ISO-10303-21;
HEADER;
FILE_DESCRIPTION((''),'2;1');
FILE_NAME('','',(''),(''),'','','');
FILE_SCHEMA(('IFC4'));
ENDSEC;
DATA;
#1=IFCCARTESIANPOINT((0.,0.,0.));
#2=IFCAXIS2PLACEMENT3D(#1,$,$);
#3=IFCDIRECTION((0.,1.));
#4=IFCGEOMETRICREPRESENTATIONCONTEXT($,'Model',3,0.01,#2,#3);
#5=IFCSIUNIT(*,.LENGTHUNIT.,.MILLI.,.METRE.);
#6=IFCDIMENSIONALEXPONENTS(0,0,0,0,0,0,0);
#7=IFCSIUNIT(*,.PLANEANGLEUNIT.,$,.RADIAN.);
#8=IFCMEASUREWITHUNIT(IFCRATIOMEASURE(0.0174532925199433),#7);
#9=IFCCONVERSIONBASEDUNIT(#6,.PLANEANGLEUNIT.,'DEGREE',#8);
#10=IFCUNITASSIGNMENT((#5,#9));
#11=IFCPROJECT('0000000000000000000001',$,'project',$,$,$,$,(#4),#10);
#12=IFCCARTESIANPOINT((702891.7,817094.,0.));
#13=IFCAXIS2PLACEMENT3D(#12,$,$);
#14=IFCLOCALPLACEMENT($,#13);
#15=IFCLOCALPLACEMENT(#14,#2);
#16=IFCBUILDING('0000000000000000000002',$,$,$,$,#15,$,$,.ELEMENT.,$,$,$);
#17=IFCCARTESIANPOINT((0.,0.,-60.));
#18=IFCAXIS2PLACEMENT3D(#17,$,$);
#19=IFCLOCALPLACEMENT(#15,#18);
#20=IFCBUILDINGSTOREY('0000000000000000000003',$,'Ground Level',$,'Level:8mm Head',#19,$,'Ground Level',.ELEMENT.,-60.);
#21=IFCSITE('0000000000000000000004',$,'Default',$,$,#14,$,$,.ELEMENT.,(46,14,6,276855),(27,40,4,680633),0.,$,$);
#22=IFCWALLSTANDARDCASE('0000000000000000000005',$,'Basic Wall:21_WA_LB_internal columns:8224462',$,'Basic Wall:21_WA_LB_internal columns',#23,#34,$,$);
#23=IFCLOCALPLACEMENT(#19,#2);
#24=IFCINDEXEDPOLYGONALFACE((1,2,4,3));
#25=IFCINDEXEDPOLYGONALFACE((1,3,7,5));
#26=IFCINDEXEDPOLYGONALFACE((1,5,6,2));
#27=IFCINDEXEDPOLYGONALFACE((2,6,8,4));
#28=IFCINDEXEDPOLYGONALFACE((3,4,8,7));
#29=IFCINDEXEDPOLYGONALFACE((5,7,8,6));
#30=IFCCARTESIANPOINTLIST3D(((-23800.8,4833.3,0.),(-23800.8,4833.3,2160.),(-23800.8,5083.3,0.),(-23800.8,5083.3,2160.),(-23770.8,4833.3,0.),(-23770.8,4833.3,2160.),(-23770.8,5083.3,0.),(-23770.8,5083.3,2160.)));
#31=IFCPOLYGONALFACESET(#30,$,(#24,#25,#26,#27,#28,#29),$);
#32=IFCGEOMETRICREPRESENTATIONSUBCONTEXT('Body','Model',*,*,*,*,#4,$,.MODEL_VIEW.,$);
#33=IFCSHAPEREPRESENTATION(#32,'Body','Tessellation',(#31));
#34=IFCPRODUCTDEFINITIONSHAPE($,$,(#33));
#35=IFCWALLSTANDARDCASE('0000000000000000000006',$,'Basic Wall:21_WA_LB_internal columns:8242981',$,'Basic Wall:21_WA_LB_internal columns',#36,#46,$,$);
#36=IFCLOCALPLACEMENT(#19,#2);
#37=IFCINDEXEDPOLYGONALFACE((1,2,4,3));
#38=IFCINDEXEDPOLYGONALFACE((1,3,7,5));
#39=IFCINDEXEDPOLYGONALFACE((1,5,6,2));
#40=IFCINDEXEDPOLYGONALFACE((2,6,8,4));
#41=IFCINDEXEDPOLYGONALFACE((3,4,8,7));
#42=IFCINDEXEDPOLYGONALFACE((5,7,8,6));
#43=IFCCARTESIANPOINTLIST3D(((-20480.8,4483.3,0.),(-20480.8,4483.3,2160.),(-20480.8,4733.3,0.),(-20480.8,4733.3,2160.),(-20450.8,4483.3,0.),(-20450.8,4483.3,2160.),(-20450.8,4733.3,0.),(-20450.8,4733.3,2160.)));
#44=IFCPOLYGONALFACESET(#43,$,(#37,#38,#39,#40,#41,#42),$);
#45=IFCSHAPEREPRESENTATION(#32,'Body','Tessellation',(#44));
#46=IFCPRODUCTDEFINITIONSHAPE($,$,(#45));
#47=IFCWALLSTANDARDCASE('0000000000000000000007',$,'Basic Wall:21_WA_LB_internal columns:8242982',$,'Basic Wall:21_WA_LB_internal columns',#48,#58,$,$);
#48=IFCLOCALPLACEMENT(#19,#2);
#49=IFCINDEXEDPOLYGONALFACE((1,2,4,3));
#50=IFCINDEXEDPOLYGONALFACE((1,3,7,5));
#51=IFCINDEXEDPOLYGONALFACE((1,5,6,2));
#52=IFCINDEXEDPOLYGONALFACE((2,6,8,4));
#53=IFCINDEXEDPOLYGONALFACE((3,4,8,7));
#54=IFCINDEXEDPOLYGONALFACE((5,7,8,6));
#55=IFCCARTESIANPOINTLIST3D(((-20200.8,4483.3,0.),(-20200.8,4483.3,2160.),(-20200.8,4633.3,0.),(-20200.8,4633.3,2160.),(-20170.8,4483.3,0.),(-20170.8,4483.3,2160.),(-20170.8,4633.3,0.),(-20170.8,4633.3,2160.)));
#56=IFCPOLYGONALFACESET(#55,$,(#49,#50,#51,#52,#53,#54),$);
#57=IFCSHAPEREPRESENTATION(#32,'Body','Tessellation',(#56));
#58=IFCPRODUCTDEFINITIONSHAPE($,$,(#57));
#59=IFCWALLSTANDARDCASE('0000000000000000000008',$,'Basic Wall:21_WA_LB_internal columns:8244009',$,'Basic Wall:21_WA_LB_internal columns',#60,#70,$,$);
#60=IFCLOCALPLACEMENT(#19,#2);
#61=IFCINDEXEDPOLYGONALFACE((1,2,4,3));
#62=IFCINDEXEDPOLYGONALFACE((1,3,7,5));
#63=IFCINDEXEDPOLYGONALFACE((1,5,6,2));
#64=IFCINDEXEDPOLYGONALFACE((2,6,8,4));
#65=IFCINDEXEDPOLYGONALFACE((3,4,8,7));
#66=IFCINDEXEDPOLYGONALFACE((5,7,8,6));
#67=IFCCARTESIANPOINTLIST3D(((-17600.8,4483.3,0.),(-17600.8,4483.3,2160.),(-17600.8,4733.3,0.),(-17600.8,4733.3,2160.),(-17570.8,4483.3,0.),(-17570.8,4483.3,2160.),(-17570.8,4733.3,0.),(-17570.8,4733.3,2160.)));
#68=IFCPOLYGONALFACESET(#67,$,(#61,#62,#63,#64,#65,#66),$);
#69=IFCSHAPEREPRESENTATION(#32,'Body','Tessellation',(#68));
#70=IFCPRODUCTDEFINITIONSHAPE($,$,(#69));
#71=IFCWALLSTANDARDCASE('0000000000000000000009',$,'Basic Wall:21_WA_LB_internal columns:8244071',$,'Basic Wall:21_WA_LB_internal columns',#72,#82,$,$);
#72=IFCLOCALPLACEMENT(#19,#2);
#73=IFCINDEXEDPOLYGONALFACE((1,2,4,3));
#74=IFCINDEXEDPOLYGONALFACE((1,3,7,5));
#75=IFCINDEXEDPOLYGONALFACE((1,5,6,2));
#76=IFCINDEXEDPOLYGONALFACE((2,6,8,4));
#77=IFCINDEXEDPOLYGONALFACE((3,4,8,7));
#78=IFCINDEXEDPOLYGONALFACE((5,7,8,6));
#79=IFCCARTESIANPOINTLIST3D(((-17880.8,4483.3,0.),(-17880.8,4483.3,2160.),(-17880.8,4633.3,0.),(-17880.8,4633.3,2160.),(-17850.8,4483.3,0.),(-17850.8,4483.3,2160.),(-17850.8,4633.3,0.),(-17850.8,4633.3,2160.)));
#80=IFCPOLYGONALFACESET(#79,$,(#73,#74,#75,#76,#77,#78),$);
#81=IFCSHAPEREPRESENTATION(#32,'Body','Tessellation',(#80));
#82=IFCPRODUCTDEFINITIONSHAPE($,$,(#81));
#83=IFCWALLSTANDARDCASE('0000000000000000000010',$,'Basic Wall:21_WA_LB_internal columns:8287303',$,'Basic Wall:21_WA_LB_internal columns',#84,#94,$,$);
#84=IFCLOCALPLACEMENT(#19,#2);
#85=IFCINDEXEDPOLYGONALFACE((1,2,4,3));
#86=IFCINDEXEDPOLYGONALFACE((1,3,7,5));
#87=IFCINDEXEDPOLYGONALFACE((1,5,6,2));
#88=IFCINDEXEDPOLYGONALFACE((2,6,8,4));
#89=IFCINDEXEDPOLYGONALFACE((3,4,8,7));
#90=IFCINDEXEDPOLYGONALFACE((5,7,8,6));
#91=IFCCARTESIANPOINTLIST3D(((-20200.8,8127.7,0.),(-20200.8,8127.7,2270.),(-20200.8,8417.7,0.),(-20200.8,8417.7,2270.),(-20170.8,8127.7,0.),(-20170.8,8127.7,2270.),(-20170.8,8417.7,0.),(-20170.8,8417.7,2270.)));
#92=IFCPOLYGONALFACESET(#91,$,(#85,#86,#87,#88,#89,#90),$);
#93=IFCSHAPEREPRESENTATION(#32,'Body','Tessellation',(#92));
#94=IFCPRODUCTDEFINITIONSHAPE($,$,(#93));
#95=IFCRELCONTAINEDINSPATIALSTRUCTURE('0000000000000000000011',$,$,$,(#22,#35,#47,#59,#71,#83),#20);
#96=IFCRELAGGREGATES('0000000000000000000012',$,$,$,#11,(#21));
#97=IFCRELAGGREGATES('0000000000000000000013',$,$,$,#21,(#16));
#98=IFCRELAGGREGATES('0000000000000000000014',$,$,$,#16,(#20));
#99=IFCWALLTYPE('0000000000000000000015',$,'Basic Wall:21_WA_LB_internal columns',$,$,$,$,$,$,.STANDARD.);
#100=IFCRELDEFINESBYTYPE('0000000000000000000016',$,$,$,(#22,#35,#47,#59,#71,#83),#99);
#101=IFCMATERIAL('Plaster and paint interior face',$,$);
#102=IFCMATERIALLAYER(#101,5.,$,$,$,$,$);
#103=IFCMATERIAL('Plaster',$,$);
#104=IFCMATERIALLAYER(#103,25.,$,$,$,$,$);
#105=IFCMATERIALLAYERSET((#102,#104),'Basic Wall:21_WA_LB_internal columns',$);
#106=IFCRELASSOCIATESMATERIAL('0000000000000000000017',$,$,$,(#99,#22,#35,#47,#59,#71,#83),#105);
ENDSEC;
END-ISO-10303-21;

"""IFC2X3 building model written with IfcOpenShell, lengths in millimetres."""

from ifc_helpers import new_model, entity, si_unit, converted_unit, direction, frame, frame_2d, origin, place, context, subcontext, project, spatial, rectangle, extrude, material, layer, layer_set, layer_usage, type_object, element, save


model = new_model("IFC2X3")

# Units and contexts
model_context = context("Model", 3, precision=0.01, world=origin(), true_north=direction((0.0, 1.0)))
body_context = subcontext(model_context, "Body", "Model", "MODEL_VIEW")
ifc_project = project(units=[si_unit("LENGTHUNIT", "METRE", prefix="MILLI"), converted_unit("PLANEANGLEUNIT", "DEGREE", entity("IfcRatioMeasure", 0.0174532925199433), si_unit("PLANEANGLEUNIT", "RADIAN"), dimensions=[0, 0, 0, 0, 0, 0, 0])], contexts=[model_context])

# Site, building, storey
site_placement = place(None, frame((702891.7, 817094.0, 0.0)))
site = spatial("IfcSite", under=ifc_project, at=site_placement, Name="Default", CompositionType="ELEMENT", RefLatitude=(46, 14, 6, 276855), RefLongitude=(27, 40, 4, 680633), RefElevation=0.0)
building_placement = place(site_placement, origin())
building = spatial("IfcBuilding", under=site, at=building_placement, CompositionType="ELEMENT")
storey_placement = place(building_placement, frame((0.0, 0.0, -60.0)))
storey = spatial("IfcBuildingStorey", under=building, at=storey_placement, Name="Ground Level", ObjectType="Level:8mm Head", LongName="Ground Level", CompositionType="ELEMENT", Elevation=-60.0)

# Shared definitions
ifc_material_1 = material(Name="Plaster")
ifc_material_2 = material(Name="Plaster and paint interior face")

# Walls
ifc_layer_1 = layer(ifc_material_2, 5.0)
ifc_layer_2 = layer(ifc_material_1, 25.0)
ifc_layer_set_1 = layer_set([ifc_layer_1, ifc_layer_2], Name="Basic Wall:21_WA_LB_internal columns")
ifc_layer_usage_1 = layer_usage(ifc_layer_set_1, "AXIS2", "NEGATIVE", 15.0)
wall_type_1 = type_object("IfcWallType", Name="Basic Wall:21_WA_LB_internal columns", PredefinedType="STANDARD", material=ifc_layer_set_1)
wall_1_placement = place(storey_placement, frame((-23785.8, 5083.3, 0.0), z_axis=(0.0, 0.0, 1.0), x_axis=(0.0, -1.0, 0.0)))
element("IfcWallStandardCase", 1, at=wall_1_placement, inside=storey, type_object=wall_type_1, material=ifc_layer_usage_1, Name="Basic Wall:21_WA_LB_internal columns:8224462", ObjectType="Basic Wall:21_WA_LB_internal columns", context=body_context, shape_type="SweptSolid", body=[
    extrude(rectangle(XDim=250.0, YDim=30.0, at=frame_2d((125.0, 0.0), x_axis=(-1.0, 0.0))), origin(), (0.0, 0.0, 1.0), 2160.0),
])
ifc_layer_usage_2 = layer_usage(ifc_layer_set_1, "AXIS2", "POSITIVE", -15.0)
wall_2_placement = place(storey_placement, frame((-20465.8, 4733.3, 0.0), z_axis=(0.0, 0.0, 1.0), x_axis=(0.0, -1.0, 0.0)))
element("IfcWallStandardCase", 2, at=wall_2_placement, inside=storey, type_object=wall_type_1, material=ifc_layer_usage_2, Name="Basic Wall:21_WA_LB_internal columns:8242981", ObjectType="Basic Wall:21_WA_LB_internal columns", context=body_context, shape_type="SweptSolid", body=[
    extrude(rectangle(XDim=250.0, YDim=30.0, at=frame_2d((125.0, 0.0), x_axis=(-1.0, 0.0))), origin(), (0.0, 0.0, 1.0), 2160.0),
])
ifc_layer_usage_3 = layer_usage(ifc_layer_set_1, "AXIS2", "NEGATIVE", 15.0)
wall_3_placement = place(storey_placement, frame((-20185.8, 4633.3, 0.0), z_axis=(0.0, 0.0, 1.0), x_axis=(0.0, -1.0, 0.0)))
element("IfcWallStandardCase", 3, at=wall_3_placement, inside=storey, type_object=wall_type_1, material=ifc_layer_usage_3, Name="Basic Wall:21_WA_LB_internal columns:8242982", ObjectType="Basic Wall:21_WA_LB_internal columns", context=body_context, shape_type="SweptSolid", body=[
    extrude(rectangle(XDim=150.0, YDim=30.0, at=frame_2d((75.0, 0.0), x_axis=(-1.0, 0.0))), origin(), (0.0, 0.0, 1.0), 2160.0),
])
ifc_layer_usage_4 = layer_usage(ifc_layer_set_1, "AXIS2", "POSITIVE", -15.0)
wall_4_placement = place(storey_placement, frame((-17585.8, 4483.3, 0.0), z_axis=(0.0, 0.0, 1.0), x_axis=(0.0, 1.0, 0.0)))
element("IfcWallStandardCase", 4, at=wall_4_placement, inside=storey, type_object=wall_type_1, material=ifc_layer_usage_4, Name="Basic Wall:21_WA_LB_internal columns:8244009", ObjectType="Basic Wall:21_WA_LB_internal columns", context=body_context, shape_type="SweptSolid", body=[
    extrude(rectangle(XDim=250.0, YDim=30.0, at=frame_2d((125.0, 0.0), x_axis=(-1.0, 0.0))), origin(), (0.0, 0.0, 1.0), 2160.0),
])
ifc_layer_usage_5 = layer_usage(ifc_layer_set_1, "AXIS2", "NEGATIVE", 15.0)
wall_5_placement = place(storey_placement, frame((-17865.8, 4483.3, 0.0), z_axis=(0.0, 0.0, 1.0), x_axis=(0.0, 1.0, 0.0)))
element("IfcWallStandardCase", 5, at=wall_5_placement, inside=storey, type_object=wall_type_1, material=ifc_layer_usage_5, Name="Basic Wall:21_WA_LB_internal columns:8244071", ObjectType="Basic Wall:21_WA_LB_internal columns", context=body_context, shape_type="SweptSolid", body=[
    extrude(rectangle(XDim=150.0, YDim=30.0, at=frame_2d((75.0, 0.0), x_axis=(-1.0, 0.0))), origin(), (0.0, 0.0, 1.0), 2160.0),
])
ifc_layer_usage_6 = layer_usage(ifc_layer_set_1, "AXIS2", "NEGATIVE", 15.0)
wall_6_placement = place(storey_placement, frame((-20185.8, 8417.7, 0.0), z_axis=(0.0, 0.0, 1.0), x_axis=(0.0, -1.0, 0.0)))
element("IfcWallStandardCase", 6, at=wall_6_placement, inside=storey, type_object=wall_type_1, material=ifc_layer_usage_6, Name="Basic Wall:21_WA_LB_internal columns:8287303", ObjectType="Basic Wall:21_WA_LB_internal columns", context=body_context, shape_type="SweptSolid", body=[
    extrude(rectangle(XDim=290.0, YDim=30.0, at=frame_2d((145.0, 0.0), x_axis=(-1.0, 0.0))), origin(), (0.0, 0.0, 1.0), 2270.0),
])

save(model, "model.ifc")
